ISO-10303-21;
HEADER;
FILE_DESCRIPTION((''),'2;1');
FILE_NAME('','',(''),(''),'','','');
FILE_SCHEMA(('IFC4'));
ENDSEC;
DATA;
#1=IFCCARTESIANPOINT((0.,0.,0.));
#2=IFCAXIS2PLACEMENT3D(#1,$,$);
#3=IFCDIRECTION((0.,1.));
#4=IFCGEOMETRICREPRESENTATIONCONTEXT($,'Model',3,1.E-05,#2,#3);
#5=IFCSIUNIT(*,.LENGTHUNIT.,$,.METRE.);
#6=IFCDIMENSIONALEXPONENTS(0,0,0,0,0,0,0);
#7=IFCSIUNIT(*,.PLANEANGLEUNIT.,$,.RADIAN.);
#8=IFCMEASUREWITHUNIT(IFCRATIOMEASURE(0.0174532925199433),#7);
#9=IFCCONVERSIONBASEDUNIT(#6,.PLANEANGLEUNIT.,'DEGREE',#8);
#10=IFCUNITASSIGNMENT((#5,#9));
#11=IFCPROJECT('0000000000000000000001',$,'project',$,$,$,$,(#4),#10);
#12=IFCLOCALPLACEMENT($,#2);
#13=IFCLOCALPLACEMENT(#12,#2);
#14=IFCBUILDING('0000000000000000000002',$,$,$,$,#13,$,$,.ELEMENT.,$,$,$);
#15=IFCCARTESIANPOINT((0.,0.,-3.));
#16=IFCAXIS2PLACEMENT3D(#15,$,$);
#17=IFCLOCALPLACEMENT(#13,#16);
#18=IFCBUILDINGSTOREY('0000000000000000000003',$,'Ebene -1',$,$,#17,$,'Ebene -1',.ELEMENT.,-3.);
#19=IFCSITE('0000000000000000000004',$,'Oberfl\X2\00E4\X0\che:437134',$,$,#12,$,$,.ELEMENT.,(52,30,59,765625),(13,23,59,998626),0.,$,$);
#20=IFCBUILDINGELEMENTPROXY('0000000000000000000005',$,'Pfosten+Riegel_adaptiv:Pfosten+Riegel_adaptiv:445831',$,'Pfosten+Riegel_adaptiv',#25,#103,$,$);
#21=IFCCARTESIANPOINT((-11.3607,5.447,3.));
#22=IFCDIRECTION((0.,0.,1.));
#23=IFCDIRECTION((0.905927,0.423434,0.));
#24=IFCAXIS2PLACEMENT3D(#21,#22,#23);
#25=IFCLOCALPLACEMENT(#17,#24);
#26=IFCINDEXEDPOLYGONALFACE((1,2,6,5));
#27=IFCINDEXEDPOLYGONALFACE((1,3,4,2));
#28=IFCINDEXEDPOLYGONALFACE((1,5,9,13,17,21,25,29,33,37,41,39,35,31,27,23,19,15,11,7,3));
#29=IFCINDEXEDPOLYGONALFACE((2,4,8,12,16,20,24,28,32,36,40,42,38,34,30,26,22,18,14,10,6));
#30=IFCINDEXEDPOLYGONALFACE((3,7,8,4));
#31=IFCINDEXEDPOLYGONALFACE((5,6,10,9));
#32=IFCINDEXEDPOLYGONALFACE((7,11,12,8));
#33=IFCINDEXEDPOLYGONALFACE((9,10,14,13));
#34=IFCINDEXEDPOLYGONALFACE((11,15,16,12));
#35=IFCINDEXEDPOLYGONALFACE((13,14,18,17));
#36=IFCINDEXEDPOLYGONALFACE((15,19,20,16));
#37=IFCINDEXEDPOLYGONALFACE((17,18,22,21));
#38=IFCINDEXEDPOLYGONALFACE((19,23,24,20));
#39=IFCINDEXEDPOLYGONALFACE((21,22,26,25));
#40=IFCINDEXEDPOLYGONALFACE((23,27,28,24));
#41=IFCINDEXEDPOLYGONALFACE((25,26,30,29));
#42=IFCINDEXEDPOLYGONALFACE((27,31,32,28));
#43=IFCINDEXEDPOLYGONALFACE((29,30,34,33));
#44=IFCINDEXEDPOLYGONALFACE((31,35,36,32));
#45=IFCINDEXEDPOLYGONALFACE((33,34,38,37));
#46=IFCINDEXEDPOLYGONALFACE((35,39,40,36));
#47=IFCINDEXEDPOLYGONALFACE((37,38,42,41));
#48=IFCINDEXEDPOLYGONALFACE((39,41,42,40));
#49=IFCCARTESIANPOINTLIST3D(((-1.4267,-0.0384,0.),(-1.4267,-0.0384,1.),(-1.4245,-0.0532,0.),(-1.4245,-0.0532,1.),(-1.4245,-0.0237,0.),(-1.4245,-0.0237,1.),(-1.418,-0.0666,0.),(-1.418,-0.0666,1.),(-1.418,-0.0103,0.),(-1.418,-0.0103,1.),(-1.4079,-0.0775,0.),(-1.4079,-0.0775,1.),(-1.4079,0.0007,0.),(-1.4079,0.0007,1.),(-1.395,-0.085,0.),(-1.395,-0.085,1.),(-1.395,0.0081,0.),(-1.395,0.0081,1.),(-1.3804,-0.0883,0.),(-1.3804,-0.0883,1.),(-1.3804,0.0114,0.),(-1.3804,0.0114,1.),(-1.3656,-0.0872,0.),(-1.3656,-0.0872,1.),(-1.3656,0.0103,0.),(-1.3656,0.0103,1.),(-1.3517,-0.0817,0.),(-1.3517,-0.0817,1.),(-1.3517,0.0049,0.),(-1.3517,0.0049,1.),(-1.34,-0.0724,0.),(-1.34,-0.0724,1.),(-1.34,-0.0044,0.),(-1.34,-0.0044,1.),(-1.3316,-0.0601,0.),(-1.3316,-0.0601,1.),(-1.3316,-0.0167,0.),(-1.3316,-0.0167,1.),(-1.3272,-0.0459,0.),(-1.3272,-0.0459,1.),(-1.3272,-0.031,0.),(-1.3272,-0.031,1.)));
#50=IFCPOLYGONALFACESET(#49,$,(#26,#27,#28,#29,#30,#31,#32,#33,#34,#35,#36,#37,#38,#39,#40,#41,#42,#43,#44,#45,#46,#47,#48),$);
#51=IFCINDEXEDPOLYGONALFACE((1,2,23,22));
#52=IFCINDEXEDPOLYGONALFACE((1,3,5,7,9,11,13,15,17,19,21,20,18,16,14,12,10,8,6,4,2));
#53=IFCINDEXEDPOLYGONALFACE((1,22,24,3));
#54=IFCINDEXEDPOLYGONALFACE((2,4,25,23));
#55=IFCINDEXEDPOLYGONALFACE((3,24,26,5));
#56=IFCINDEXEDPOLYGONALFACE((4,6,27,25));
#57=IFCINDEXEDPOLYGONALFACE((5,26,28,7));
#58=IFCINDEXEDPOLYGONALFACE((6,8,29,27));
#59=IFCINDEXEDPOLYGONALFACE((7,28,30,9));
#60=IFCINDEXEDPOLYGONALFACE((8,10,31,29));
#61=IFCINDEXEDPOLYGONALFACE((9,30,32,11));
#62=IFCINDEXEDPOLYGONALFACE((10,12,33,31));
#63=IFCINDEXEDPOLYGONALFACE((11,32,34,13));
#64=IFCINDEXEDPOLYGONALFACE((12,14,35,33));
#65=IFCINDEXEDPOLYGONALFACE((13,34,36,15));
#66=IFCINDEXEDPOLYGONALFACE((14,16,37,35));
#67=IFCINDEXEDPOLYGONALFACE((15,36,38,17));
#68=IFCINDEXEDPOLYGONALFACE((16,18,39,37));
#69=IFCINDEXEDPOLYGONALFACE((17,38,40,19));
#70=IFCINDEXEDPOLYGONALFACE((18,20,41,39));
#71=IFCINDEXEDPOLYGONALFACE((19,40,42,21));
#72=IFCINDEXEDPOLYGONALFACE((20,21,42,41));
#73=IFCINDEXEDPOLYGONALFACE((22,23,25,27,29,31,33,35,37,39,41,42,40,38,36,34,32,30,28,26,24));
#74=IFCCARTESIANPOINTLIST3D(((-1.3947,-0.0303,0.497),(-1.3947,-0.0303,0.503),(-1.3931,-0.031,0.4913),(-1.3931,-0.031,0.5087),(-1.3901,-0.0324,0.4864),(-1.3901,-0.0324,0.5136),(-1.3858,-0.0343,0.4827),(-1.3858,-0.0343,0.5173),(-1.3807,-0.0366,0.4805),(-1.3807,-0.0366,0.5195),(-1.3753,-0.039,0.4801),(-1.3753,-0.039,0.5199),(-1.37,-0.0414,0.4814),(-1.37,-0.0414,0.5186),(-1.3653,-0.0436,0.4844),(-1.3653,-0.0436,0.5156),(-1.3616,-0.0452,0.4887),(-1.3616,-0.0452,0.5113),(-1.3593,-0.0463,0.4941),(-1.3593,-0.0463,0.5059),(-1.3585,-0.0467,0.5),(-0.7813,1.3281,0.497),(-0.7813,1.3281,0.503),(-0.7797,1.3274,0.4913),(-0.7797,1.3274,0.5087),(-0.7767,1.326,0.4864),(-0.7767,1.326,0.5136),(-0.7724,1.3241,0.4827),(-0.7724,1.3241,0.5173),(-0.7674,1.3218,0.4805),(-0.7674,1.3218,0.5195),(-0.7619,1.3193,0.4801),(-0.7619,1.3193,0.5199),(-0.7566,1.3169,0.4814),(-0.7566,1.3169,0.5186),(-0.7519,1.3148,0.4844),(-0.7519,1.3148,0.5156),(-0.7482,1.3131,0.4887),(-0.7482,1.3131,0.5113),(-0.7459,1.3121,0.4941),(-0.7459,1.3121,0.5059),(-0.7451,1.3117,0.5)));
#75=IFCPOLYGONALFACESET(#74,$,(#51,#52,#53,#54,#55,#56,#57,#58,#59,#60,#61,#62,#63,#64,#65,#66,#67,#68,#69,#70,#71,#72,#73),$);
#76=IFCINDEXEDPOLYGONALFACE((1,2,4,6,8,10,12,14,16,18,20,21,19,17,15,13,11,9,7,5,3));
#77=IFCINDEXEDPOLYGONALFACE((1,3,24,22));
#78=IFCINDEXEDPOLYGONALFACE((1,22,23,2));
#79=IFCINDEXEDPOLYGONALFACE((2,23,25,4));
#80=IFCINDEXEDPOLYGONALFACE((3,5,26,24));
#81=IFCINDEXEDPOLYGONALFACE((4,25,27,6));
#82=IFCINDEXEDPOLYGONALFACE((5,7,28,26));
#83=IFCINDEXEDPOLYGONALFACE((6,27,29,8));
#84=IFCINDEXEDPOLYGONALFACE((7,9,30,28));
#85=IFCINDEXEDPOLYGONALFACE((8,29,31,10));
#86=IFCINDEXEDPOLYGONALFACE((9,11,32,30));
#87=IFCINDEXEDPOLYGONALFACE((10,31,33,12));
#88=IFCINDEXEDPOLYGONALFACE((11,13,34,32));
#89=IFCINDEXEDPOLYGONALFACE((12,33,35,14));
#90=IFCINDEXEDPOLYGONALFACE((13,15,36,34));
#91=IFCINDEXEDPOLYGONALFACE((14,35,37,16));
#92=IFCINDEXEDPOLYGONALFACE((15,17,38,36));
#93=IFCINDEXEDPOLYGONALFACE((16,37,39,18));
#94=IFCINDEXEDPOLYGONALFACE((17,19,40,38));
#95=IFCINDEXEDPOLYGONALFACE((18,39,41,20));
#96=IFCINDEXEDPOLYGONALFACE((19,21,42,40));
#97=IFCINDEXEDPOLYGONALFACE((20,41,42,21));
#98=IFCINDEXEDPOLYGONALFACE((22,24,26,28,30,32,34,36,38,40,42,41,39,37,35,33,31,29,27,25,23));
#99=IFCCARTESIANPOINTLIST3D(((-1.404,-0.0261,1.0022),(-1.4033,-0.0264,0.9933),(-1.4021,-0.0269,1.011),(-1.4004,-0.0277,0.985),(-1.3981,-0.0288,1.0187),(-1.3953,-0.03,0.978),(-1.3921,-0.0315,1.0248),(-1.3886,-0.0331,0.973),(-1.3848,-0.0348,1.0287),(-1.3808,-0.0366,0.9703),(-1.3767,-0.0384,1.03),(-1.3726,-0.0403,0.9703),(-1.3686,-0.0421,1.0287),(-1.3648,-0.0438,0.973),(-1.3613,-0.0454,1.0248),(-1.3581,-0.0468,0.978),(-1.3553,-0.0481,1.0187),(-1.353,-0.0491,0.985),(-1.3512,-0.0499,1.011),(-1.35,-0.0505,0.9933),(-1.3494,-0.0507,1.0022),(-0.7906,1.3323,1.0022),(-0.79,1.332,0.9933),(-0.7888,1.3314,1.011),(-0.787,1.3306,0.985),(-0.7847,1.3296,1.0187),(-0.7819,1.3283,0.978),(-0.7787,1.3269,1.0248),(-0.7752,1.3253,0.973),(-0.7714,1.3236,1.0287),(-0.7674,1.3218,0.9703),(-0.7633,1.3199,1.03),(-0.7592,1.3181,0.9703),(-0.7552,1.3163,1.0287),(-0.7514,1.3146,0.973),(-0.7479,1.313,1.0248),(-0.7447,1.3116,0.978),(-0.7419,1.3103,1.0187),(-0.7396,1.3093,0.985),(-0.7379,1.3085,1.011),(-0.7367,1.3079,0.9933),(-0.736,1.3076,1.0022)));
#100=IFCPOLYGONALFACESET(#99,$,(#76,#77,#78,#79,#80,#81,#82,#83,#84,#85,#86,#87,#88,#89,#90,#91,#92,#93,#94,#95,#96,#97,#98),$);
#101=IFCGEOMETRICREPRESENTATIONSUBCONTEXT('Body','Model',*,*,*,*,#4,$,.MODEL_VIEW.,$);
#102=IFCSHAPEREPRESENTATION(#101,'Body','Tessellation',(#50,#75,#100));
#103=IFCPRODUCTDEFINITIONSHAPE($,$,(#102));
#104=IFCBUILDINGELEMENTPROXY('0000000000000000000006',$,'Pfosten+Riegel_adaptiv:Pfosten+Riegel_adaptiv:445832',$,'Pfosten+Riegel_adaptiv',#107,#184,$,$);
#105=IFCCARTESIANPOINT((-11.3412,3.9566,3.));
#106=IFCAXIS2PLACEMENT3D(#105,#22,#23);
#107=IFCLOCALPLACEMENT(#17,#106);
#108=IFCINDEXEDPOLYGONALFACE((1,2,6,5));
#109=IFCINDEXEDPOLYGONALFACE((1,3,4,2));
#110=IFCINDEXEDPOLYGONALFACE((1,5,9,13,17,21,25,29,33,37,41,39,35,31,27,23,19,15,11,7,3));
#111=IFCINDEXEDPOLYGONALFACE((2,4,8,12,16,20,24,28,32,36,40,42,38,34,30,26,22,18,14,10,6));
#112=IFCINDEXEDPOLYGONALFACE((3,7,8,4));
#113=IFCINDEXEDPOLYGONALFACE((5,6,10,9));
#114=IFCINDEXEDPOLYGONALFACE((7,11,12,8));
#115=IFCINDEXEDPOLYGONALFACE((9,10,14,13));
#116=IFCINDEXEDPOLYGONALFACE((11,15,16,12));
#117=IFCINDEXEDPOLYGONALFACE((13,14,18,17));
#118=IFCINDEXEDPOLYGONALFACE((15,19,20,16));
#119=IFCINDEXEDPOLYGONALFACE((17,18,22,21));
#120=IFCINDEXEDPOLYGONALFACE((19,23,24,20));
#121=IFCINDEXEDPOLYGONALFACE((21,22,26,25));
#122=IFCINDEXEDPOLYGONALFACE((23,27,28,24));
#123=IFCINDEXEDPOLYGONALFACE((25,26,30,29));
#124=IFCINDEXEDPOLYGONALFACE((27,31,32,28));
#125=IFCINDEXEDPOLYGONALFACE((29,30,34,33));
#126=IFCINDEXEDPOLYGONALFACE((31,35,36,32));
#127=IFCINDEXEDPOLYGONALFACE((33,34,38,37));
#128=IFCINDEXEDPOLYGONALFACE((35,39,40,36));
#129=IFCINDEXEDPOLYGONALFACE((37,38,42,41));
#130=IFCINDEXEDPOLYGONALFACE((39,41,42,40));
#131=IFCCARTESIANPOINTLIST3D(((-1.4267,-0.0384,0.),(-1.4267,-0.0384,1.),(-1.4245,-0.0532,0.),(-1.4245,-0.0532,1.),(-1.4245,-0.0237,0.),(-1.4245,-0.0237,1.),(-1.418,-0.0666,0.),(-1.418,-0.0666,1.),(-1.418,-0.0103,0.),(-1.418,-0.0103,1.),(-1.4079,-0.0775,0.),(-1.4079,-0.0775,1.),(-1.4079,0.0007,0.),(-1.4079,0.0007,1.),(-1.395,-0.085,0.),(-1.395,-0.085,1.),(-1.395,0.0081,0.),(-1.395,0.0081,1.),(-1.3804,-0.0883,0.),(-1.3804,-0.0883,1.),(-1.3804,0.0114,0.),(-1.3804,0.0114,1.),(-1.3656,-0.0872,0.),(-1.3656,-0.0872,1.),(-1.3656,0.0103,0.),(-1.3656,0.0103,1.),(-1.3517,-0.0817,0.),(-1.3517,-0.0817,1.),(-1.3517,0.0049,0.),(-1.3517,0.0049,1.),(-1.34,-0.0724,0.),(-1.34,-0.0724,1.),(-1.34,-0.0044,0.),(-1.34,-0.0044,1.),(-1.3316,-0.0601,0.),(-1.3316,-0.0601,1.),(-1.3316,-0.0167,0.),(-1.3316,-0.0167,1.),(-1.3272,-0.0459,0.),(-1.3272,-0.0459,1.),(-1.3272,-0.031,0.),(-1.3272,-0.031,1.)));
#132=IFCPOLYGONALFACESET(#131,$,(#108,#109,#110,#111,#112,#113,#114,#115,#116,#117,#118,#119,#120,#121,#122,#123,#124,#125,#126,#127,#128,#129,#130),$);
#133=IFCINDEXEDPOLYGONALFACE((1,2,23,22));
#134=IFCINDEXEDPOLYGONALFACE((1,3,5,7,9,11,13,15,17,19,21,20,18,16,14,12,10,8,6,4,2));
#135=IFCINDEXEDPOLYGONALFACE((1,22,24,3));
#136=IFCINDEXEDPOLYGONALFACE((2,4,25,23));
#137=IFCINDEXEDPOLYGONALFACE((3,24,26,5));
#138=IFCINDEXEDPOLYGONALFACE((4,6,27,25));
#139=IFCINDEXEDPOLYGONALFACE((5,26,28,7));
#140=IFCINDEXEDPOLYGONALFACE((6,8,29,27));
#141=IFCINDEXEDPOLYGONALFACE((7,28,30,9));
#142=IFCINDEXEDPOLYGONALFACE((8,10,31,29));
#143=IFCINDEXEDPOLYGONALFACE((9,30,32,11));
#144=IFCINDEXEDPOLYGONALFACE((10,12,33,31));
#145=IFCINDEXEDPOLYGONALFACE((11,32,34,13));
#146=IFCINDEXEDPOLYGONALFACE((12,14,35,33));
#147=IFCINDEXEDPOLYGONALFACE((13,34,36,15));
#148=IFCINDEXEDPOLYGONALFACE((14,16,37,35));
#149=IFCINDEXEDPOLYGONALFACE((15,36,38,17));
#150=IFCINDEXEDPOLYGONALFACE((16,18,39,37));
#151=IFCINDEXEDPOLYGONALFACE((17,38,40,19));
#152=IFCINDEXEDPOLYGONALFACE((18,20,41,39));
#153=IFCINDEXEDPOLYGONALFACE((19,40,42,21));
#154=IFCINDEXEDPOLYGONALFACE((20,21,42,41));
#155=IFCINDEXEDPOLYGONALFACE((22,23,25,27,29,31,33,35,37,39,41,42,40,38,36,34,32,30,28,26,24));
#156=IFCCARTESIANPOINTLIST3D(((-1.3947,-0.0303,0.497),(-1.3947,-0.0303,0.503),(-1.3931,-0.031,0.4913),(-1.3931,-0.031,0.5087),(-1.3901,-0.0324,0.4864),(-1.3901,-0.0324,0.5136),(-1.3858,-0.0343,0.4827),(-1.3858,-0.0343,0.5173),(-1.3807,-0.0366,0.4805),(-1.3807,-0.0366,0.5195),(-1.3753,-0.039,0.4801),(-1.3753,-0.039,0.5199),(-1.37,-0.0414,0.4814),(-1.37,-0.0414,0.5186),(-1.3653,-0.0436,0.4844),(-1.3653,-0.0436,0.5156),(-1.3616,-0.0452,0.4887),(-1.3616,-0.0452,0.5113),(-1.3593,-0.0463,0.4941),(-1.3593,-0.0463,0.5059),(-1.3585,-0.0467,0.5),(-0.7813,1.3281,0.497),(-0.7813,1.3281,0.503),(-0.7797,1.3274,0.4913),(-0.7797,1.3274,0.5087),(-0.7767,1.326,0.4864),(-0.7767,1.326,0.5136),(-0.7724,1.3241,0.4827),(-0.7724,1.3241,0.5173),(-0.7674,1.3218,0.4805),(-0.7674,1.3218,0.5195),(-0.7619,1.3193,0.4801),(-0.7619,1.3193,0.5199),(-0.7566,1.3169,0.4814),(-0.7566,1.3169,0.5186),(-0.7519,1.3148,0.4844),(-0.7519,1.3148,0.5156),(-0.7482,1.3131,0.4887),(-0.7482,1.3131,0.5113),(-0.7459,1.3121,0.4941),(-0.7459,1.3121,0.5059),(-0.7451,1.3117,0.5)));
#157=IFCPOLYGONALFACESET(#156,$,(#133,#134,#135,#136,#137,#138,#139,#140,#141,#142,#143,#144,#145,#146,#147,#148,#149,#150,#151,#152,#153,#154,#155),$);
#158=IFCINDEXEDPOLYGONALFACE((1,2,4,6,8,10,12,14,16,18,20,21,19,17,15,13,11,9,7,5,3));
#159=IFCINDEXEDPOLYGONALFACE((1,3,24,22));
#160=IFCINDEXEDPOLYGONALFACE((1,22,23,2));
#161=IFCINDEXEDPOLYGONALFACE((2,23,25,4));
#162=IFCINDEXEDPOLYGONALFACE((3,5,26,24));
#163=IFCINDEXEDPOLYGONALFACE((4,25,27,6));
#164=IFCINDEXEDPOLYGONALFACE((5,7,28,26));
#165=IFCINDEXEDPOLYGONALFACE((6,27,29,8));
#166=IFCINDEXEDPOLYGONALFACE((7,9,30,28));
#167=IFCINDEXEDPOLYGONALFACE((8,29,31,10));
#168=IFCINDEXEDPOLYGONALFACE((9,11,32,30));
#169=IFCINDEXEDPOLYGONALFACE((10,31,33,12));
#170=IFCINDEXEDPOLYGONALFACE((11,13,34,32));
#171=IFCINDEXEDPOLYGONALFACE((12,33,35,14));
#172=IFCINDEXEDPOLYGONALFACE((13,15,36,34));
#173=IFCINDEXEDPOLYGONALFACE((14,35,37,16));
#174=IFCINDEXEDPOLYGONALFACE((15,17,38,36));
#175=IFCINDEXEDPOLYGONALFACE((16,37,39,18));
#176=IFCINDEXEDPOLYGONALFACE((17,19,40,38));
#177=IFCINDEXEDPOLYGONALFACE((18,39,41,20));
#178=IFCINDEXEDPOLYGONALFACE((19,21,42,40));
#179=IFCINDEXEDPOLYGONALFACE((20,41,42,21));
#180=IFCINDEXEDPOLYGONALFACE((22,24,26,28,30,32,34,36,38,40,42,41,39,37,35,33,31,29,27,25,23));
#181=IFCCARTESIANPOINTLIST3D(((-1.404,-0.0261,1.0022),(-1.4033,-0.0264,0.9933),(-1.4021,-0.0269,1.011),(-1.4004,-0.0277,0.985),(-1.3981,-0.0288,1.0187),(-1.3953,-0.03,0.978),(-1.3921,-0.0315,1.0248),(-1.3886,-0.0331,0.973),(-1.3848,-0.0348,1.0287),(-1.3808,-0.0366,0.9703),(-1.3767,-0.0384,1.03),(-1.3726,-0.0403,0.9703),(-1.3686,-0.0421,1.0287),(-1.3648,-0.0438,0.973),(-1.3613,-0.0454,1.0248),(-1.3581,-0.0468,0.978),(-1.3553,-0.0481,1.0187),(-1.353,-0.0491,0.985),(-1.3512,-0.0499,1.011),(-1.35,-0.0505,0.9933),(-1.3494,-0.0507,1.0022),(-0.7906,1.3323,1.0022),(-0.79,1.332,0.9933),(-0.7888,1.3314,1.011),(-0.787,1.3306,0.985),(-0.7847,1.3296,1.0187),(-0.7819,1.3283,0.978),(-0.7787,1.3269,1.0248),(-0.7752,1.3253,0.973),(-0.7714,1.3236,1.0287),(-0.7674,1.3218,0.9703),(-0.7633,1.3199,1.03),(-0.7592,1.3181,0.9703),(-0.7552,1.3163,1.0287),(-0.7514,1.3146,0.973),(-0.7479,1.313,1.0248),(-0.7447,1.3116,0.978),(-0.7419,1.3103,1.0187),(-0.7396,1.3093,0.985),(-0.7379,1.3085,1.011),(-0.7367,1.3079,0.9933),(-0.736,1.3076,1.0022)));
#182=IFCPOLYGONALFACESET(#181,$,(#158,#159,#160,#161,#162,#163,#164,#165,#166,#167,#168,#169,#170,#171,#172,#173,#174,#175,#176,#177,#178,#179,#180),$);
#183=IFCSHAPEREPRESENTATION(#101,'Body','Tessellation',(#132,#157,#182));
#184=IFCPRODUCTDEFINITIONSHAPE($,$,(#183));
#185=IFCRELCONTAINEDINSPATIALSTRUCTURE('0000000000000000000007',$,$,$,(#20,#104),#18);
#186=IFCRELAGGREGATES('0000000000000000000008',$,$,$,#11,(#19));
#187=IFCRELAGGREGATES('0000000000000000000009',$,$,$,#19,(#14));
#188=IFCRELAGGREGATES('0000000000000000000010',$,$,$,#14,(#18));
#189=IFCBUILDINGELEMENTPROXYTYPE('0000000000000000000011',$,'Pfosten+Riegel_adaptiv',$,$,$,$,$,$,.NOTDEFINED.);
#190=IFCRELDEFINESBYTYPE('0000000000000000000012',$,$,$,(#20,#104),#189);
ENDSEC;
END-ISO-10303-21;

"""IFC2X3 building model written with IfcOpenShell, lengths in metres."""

from ifc_helpers import new_model, entity, si_unit, converted_unit, direction, frame, frame_2d, origin, place, context, subcontext, project, spatial, circle, extrude, source, transform, mapped, type_object, type_shapes, element, save


model = new_model("IFC2X3")

# Units and contexts
model_context = context("Model", 3, precision=1e-05, world=origin(), true_north=direction((0.0, 1.0)))
body_context = subcontext(model_context, "Body", "Model", "MODEL_VIEW")
ifc_project = project(units=[si_unit("LENGTHUNIT", "METRE"), converted_unit("PLANEANGLEUNIT", "DEGREE", entity("IfcRatioMeasure", 0.0174532925199433), si_unit("PLANEANGLEUNIT", "RADIAN"), dimensions=[0, 0, 0, 0, 0, 0, 0])], contexts=[model_context])

# Site, building, storey
site_placement = place(None, origin())
site = spatial("IfcSite", under=ifc_project, at=site_placement, Name="Oberfläche:437134", CompositionType="ELEMENT", RefLatitude=(52, 30, 59, 765625), RefLongitude=(13, 23, 59, 998626), RefElevation=0.0)
building_placement = place(site_placement, origin())
building = spatial("IfcBuilding", under=site, at=building_placement, CompositionType="ELEMENT")
storey_placement = place(building_placement, frame((0.0, 0.0, -3.0)))
storey = spatial("IfcBuildingStorey", under=building, at=storey_placement, Name="Ebene -1", LongName="Ebene -1", CompositionType="ELEMENT", Elevation=-3.0)

# Building element proxies
building_element_proxy_type_1 = type_object("IfcBuildingElementProxyType", Name="Pfosten+Riegel_adaptiv", PredefinedType="NOTDEFINED")
shared_shape_1 = source(origin(), body_context, "Body", "SweptSolid", [
    extrude(circle(Radius=0.05, at=frame_2d((0.0, 0.0), x_axis=(1.0, 0.0))), frame((-1.3767, -0.0384, 0.0), z_axis=(0.0, 0.0, 1.0), x_axis=(-1.0, 0.0, 0.0)), (0.0, 0.0, 1.0), 1.0),
    extrude(circle(Radius=0.02, at=frame_2d((0.0, 0.0), x_axis=(1.0, 0.0))), frame((-1.3767, -0.0384, 0.5), z_axis=(0.411546, 0.911389, 0.0), x_axis=(0.911389, -0.411546, 0.0)), (0.0, 0.0, 1.0), 1.4904),
    extrude(circle(Radius=0.03, at=frame_2d((0.0, 0.0), x_axis=(1.0, 0.0))), frame((-1.3767, -0.0384, 1.0), z_axis=(0.411546, 0.911389, 0.0), x_axis=(0.0, 0.0, 1.0)), (0.0, 0.0, 1.0), 1.4904),
])
type_shapes(building_element_proxy_type_1, [shared_shape_1])
for number, where, z_axis, x_axis, name in (
    (1, (-11.3607, 5.447, 3.0), (0.0, 0.0, 1.0), (0.905927, 0.423434, 0.0), "Pfosten+Riegel_adaptiv:Pfosten+Riegel_adaptiv:445831"),
    (2, (-11.3412, 3.9566, 3.0), (0.0, 0.0, 1.0), (0.905927, 0.423434, 0.0), "Pfosten+Riegel_adaptiv:Pfosten+Riegel_adaptiv:445832"),
):
    element("IfcBuildingElementProxy", number, at=place(storey_placement, frame(where, z_axis=z_axis, x_axis=x_axis)), inside=storey, type_object=building_element_proxy_type_1, Name=name, ObjectType="Pfosten+Riegel_adaptiv", context=body_context, shape_type="MappedRepresentation", body=[
        mapped(shared_shape_1, transform((0.0, 0.0, 0.0), scale=1.0)),
    ])

save(model, "model.ifc")
